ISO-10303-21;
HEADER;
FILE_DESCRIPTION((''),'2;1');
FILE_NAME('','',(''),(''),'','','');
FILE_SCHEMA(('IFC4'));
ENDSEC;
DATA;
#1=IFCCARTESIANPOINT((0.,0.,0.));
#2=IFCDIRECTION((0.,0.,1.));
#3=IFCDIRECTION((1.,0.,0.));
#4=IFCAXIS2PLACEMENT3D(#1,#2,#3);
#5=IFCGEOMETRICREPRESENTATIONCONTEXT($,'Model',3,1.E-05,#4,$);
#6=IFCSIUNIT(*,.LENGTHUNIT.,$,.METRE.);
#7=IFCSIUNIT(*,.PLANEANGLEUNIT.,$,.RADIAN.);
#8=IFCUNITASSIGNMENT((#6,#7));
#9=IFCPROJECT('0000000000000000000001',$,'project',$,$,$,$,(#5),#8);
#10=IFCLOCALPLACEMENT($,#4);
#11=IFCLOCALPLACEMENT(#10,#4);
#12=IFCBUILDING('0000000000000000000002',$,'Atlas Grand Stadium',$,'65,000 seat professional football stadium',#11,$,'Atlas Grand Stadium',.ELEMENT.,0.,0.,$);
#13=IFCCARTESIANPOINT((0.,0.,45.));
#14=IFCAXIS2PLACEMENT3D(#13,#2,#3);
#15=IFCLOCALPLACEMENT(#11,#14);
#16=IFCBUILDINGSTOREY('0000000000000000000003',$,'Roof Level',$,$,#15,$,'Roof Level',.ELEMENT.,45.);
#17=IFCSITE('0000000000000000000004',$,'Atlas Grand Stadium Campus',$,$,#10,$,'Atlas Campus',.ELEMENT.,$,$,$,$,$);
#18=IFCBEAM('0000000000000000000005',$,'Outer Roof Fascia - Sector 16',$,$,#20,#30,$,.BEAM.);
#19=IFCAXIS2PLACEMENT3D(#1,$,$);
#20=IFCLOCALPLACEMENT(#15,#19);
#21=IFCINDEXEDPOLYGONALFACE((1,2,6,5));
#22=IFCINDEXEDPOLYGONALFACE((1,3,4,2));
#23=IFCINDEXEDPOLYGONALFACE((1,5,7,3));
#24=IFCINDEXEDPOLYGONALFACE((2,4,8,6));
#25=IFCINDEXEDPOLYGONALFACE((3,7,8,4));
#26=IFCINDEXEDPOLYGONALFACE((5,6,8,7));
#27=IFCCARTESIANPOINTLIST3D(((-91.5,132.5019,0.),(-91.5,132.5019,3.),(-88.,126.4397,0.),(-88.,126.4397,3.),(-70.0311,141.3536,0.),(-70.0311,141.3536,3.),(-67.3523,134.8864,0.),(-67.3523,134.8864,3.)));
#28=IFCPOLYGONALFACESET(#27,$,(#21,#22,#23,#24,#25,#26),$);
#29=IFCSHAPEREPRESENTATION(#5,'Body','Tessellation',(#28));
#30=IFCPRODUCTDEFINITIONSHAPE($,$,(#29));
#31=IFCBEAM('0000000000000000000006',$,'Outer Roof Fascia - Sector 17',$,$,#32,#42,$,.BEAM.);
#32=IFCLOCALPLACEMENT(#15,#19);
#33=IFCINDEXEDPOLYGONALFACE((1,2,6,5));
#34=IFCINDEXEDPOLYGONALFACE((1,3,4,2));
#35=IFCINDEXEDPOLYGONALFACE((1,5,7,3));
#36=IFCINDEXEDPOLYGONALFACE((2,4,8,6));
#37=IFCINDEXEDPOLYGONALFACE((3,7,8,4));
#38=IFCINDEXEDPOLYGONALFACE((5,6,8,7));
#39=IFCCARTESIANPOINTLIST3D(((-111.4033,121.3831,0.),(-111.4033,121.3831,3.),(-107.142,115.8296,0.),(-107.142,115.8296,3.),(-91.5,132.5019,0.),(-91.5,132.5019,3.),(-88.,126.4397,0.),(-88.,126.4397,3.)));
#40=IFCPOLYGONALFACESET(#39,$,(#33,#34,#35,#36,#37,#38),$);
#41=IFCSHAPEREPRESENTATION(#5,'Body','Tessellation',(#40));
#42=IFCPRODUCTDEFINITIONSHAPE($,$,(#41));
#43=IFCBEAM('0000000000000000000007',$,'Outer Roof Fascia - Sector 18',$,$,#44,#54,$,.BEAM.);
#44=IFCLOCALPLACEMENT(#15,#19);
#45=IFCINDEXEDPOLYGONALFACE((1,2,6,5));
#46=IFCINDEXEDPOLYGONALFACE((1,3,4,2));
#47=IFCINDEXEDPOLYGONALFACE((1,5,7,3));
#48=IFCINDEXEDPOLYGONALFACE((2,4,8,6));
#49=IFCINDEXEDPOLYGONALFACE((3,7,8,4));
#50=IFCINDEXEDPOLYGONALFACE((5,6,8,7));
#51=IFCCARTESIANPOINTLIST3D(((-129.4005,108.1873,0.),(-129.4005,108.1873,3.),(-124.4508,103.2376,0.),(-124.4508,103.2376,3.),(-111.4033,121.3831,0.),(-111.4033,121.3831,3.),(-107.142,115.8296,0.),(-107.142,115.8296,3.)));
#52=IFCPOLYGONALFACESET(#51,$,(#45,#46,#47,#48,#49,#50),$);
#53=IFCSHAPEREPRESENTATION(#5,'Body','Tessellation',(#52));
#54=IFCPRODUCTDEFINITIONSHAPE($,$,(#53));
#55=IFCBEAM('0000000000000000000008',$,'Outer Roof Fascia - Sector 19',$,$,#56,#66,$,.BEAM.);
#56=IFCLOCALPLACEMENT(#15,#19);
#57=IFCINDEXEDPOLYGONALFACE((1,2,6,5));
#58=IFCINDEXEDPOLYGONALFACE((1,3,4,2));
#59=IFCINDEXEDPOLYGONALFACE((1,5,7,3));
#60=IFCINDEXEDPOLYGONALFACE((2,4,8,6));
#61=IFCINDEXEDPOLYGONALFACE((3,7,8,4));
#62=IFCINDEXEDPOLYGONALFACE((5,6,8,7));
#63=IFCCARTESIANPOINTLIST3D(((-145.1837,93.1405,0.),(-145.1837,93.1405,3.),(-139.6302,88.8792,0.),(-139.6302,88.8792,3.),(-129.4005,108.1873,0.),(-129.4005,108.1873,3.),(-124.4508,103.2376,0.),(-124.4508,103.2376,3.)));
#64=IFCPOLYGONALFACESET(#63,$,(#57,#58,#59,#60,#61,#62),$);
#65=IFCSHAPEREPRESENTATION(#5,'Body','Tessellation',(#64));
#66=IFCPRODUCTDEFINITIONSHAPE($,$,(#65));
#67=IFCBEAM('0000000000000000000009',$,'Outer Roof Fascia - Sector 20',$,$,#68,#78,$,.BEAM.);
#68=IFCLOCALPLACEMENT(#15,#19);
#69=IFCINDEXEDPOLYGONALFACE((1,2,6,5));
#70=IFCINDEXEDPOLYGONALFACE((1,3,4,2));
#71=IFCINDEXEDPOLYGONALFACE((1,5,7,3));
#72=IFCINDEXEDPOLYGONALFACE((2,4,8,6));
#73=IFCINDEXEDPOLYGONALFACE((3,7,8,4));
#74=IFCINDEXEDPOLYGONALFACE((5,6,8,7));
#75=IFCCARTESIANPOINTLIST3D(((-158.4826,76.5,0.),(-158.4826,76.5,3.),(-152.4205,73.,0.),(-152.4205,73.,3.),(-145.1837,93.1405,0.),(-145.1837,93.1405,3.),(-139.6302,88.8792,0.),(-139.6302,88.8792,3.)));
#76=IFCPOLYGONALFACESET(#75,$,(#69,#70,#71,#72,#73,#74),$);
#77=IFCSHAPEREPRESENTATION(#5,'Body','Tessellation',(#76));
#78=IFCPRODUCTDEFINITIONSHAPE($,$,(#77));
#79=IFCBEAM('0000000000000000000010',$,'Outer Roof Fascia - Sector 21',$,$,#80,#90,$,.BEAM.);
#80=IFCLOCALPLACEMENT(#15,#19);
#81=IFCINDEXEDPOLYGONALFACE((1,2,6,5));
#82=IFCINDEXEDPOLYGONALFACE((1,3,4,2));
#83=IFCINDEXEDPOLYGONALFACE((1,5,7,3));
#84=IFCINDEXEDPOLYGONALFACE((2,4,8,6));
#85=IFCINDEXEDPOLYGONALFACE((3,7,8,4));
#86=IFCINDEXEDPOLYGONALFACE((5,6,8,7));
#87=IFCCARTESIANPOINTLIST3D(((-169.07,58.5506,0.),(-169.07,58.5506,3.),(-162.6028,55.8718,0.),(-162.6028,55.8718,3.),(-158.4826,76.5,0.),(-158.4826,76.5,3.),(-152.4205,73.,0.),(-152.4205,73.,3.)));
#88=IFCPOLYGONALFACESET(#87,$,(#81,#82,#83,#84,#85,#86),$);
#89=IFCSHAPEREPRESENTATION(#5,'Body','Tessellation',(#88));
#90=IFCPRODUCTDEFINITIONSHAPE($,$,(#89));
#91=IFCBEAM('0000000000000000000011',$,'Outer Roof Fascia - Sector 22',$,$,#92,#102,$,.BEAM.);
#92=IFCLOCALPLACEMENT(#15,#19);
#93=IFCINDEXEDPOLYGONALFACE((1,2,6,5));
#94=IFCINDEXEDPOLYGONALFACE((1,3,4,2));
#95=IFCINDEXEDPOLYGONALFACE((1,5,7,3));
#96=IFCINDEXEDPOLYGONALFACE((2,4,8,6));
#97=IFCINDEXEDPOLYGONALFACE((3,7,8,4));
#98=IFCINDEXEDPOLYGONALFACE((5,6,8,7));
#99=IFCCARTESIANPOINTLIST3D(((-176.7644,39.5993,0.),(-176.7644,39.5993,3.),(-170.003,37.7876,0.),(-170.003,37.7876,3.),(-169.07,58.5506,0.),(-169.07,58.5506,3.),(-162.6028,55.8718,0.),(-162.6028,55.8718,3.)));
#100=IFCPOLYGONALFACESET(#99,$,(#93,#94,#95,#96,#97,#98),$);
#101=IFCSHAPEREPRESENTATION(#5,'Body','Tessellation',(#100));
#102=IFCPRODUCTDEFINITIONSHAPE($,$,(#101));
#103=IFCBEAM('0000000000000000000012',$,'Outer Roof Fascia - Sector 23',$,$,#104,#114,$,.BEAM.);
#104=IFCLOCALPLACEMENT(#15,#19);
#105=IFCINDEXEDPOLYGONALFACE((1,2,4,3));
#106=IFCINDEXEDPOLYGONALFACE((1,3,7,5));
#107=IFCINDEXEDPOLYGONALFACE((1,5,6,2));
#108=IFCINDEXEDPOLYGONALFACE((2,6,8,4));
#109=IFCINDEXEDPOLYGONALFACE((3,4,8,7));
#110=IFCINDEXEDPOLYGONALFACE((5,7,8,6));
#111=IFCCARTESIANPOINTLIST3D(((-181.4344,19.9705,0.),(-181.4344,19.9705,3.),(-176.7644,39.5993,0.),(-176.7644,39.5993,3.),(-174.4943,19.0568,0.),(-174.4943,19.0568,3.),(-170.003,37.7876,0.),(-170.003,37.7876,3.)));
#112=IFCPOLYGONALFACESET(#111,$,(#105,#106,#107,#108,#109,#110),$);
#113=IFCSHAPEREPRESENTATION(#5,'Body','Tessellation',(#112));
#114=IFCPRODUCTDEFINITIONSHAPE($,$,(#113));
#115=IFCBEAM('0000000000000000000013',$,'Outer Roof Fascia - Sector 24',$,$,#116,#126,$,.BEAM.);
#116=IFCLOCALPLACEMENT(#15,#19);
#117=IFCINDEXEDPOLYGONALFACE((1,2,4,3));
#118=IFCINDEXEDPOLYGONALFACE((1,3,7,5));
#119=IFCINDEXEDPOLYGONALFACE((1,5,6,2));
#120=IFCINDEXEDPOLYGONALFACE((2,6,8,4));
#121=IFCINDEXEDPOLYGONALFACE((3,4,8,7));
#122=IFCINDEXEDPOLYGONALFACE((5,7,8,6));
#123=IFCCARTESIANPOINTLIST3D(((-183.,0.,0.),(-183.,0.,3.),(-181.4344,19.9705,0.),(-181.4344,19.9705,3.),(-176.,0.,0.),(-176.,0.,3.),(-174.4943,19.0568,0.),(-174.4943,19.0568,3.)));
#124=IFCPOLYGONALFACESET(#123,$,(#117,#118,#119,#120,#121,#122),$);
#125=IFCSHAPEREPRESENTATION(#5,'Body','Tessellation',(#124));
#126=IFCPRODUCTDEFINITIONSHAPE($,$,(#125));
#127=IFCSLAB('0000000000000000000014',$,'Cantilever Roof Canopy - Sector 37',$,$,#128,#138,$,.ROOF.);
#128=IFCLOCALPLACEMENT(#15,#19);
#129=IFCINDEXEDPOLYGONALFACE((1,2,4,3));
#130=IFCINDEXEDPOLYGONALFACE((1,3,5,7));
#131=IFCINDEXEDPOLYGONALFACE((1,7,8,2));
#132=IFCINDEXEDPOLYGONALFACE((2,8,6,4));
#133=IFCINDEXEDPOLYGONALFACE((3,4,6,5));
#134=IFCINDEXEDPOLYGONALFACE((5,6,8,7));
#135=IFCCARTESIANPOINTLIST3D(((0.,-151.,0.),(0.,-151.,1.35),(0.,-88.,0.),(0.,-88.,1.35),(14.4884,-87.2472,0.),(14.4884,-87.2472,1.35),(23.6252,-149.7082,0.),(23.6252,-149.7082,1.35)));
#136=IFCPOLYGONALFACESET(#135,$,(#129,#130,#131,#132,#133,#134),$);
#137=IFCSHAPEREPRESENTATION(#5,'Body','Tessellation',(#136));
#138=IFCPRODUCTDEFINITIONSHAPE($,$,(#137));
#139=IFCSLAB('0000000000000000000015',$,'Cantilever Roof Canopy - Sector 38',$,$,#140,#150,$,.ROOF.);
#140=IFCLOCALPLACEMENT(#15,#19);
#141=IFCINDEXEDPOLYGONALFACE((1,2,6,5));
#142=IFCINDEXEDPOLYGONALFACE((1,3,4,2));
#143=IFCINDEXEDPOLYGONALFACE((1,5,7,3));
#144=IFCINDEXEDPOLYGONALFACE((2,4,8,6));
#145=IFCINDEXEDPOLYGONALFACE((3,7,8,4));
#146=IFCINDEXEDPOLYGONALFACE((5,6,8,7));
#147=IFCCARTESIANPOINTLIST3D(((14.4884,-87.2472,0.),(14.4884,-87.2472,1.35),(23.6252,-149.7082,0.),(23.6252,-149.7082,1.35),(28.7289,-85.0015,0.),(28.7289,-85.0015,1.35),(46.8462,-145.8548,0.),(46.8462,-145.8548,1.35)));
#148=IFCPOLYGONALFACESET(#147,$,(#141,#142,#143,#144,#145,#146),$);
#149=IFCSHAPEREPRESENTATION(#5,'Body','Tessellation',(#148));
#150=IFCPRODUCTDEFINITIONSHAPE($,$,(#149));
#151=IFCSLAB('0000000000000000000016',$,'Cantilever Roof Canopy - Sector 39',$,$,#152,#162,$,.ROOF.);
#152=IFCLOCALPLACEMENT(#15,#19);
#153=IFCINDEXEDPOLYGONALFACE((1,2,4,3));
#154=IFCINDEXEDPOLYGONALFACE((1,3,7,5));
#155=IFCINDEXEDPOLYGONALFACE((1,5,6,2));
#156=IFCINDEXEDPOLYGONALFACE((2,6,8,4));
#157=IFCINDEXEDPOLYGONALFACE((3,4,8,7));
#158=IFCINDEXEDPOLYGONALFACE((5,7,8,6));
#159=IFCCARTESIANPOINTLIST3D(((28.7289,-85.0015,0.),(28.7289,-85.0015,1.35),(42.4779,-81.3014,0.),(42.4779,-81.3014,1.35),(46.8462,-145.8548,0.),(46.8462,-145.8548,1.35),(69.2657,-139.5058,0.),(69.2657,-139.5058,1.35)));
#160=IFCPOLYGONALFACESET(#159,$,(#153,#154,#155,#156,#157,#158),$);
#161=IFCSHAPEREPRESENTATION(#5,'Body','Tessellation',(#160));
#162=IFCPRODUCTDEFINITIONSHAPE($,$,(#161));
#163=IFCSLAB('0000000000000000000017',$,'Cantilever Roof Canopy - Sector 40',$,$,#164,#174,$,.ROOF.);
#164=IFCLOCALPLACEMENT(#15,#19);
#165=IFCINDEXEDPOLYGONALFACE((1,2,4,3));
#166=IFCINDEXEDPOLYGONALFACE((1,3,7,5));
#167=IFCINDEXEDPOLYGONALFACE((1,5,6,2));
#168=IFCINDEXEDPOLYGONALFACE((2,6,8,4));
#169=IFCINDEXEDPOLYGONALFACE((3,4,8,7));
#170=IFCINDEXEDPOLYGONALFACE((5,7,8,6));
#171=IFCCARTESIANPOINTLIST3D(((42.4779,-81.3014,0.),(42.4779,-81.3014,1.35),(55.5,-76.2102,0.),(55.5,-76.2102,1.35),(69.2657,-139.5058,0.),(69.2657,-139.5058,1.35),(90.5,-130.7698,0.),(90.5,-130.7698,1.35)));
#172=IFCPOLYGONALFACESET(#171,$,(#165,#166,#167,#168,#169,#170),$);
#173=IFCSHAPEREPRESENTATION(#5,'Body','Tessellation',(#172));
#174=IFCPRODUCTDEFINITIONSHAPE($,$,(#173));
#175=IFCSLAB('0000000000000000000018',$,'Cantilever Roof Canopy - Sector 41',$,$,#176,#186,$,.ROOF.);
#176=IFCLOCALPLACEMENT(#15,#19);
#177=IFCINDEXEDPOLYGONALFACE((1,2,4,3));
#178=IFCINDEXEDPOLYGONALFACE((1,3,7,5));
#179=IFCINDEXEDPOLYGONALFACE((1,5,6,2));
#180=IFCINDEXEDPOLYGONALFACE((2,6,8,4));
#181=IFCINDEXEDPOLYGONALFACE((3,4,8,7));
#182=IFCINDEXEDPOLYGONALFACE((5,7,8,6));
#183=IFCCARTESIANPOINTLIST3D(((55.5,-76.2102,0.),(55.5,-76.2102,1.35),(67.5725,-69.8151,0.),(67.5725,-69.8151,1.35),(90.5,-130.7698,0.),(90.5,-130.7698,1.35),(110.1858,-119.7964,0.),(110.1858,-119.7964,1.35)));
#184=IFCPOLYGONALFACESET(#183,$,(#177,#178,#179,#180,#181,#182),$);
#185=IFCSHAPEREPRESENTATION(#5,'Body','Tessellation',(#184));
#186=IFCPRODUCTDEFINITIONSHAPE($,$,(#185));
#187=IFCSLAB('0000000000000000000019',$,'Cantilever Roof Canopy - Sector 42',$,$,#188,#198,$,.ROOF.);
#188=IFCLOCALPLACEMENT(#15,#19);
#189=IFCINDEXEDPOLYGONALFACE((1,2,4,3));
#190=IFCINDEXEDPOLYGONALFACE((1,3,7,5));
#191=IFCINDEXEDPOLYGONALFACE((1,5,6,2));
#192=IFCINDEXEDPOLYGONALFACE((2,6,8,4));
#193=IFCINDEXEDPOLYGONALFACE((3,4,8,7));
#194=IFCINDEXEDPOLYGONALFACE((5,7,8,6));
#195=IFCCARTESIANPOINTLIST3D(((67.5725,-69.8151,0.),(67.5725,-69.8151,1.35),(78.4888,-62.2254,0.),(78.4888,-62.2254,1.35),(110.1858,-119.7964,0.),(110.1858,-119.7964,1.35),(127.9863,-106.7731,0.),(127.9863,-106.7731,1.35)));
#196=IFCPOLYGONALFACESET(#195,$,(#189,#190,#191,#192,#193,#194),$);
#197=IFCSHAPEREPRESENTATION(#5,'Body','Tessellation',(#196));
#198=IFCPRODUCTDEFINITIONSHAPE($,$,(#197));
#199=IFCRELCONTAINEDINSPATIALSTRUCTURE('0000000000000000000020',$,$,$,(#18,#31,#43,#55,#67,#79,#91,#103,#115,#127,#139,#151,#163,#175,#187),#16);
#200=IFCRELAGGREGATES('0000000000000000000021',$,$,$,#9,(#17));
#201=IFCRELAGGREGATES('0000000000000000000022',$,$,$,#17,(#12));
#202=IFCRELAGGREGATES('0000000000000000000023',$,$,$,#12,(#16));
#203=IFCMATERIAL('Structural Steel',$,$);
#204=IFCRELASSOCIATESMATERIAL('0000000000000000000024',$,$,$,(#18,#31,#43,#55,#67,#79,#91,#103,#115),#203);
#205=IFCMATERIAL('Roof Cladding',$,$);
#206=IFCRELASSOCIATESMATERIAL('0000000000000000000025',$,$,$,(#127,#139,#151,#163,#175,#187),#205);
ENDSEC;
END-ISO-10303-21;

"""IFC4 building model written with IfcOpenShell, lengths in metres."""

from ifc_helpers import new_model, si_unit, frame, origin_with_axes, place, context, project, spatial, polyline, outline, extrude, material, element, save


model = new_model("IFC4")

# Units and contexts
model_context = context("Model", 3, precision=1e-05, world=origin_with_axes())
ifc_project = project(units=[si_unit("LENGTHUNIT", "METRE"), si_unit("PLANEANGLEUNIT", "RADIAN")], contexts=[model_context])

# Site, building, storey
site_placement = place(None, origin_with_axes())
site = spatial("IfcSite", under=ifc_project, at=site_placement, Name="Atlas Grand Stadium Campus", LongName="Atlas Campus", CompositionType="ELEMENT")
building_placement = place(site_placement, origin_with_axes())
building = spatial("IfcBuilding", under=site, at=building_placement, Name="Atlas Grand Stadium", ObjectType="65,000 seat professional football stadium", LongName="Atlas Grand Stadium", CompositionType="ELEMENT", ElevationOfRefHeight=0.0, ElevationOfTerrain=0.0)
storey_placement = place(building_placement, frame((0.0, 0.0, 45.0), z_axis=(0.0, 0.0, 1.0), x_axis=(1.0, 0.0, 0.0)))
storey = spatial("IfcBuildingStorey", under=building, at=storey_placement, Name="Roof Level", LongName="Roof Level", CompositionType="ELEMENT", Elevation=45.0)

# Beams
ifc_material_1 = material(Name="Structural Steel")
beam_1_placement = place(storey_placement, origin_with_axes())
element("IfcBeam", 1, at=beam_1_placement, inside=storey, material=ifc_material_1, Name="Outer Roof Fascia - Sector 16", PredefinedType="BEAM", context=model_context, shape_type="SweptSolid", body=[
    extrude(outline(polyline([(-70.0311, 141.3536), (-91.5, 132.5019), (-88.0, 126.4397), (-67.3523, 134.8864), (-70.0311, 141.3536)])), origin_with_axes(), (0.0, 0.0, 1.0), 3.0),
])
beam_2_placement = place(storey_placement, origin_with_axes())
element("IfcBeam", 2, at=beam_2_placement, inside=storey, material=ifc_material_1, Name="Outer Roof Fascia - Sector 17", PredefinedType="BEAM", context=model_context, shape_type="SweptSolid", body=[
    extrude(outline(polyline([(-91.5, 132.5019), (-111.4033, 121.3831), (-107.142, 115.8296), (-88.0, 126.4397), (-91.5, 132.5019)])), origin_with_axes(), (0.0, 0.0, 1.0), 3.0),
])
beam_3_placement = place(storey_placement, origin_with_axes())
element("IfcBeam", 3, at=beam_3_placement, inside=storey, material=ifc_material_1, Name="Outer Roof Fascia - Sector 18", PredefinedType="BEAM", context=model_context, shape_type="SweptSolid", body=[
    extrude(outline(polyline([(-111.4033, 121.3831), (-129.4005, 108.1873), (-124.4508, 103.2376), (-107.142, 115.8296), (-111.4033, 121.3831)])), origin_with_axes(), (0.0, 0.0, 1.0), 3.0),
])
beam_4_placement = place(storey_placement, origin_with_axes())
element("IfcBeam", 4, at=beam_4_placement, inside=storey, material=ifc_material_1, Name="Outer Roof Fascia - Sector 19", PredefinedType="BEAM", context=model_context, shape_type="SweptSolid", body=[
    extrude(outline(polyline([(-129.4005, 108.1873), (-145.1837, 93.1405), (-139.6302, 88.8792), (-124.4508, 103.2376), (-129.4005, 108.1873)])), origin_with_axes(), (0.0, 0.0, 1.0), 3.0),
])
beam_5_placement = place(storey_placement, origin_with_axes())
element("IfcBeam", 5, at=beam_5_placement, inside=storey, material=ifc_material_1, Name="Outer Roof Fascia - Sector 20", PredefinedType="BEAM", context=model_context, shape_type="SweptSolid", body=[
    extrude(outline(polyline([(-145.1837, 93.1405), (-158.4827, 76.5), (-152.4205, 73.0), (-139.6302, 88.8792), (-145.1837, 93.1405)])), origin_with_axes(), (0.0, 0.0, 1.0), 3.0),
])
beam_6_placement = place(storey_placement, origin_with_axes())
element("IfcBeam", 6, at=beam_6_placement, inside=storey, material=ifc_material_1, Name="Outer Roof Fascia - Sector 21", PredefinedType="BEAM", context=model_context, shape_type="SweptSolid", body=[
    extrude(outline(polyline([(-158.4827, 76.5), (-169.07, 58.5506), (-162.6028, 55.8718), (-152.4205, 73.0), (-158.4827, 76.5)])), origin_with_axes(), (0.0, 0.0, 1.0), 3.0),
])
beam_7_placement = place(storey_placement, origin_with_axes())
element("IfcBeam", 7, at=beam_7_placement, inside=storey, material=ifc_material_1, Name="Outer Roof Fascia - Sector 22", PredefinedType="BEAM", context=model_context, shape_type="SweptSolid", body=[
    extrude(outline(polyline([(-169.07, 58.5506), (-176.7644, 39.5993), (-170.0029, 37.7876), (-162.6028, 55.8718), (-169.07, 58.5506)])), origin_with_axes(), (0.0, 0.0, 1.0), 3.0),
])
beam_8_placement = place(storey_placement, origin_with_axes())
element("IfcBeam", 8, at=beam_8_placement, inside=storey, material=ifc_material_1, Name="Outer Roof Fascia - Sector 23", PredefinedType="BEAM", context=model_context, shape_type="SweptSolid", body=[
    extrude(outline(polyline([(-176.7644, 39.5993), (-181.4344, 19.9705), (-174.4943, 19.0568), (-170.0029, 37.7876), (-176.7644, 39.5993)])), origin_with_axes(), (0.0, 0.0, 1.0), 3.0),
])
beam_9_placement = place(storey_placement, origin_with_axes())
element("IfcBeam", 9, at=beam_9_placement, inside=storey, material=ifc_material_1, Name="Outer Roof Fascia - Sector 24", PredefinedType="BEAM", context=model_context, shape_type="SweptSolid", body=[
    extrude(outline(polyline([(-181.4344, 19.9705), (-183.0, 0.0), (-176.0, 0.0), (-174.4943, 19.0568), (-181.4344, 19.9705)])), origin_with_axes(), (0.0, 0.0, 1.0), 3.0),
])

# Slabs
ifc_material_2 = material(Name="Roof Cladding")
slab_1_placement = place(storey_placement, origin_with_axes())
element("IfcSlab", 10, at=slab_1_placement, inside=storey, material=ifc_material_2, Name="Cantilever Roof Canopy - Sector 37", PredefinedType="ROOF", context=model_context, shape_type="SweptSolid", body=[
    extrude(outline(polyline([(0.0, -151.0), (23.6252, -149.7082), (14.4884, -87.2472), (0.0, -88.0), (0.0, -151.0)])), origin_with_axes(), (0.0, 0.0, 1.0), 1.35),
])
slab_2_placement = place(storey_placement, origin_with_axes())
element("IfcSlab", 11, at=slab_2_placement, inside=storey, material=ifc_material_2, Name="Cantilever Roof Canopy - Sector 38", PredefinedType="ROOF", context=model_context, shape_type="SweptSolid", body=[
    extrude(outline(polyline([(23.6252, -149.7082), (46.8462, -145.8548), (28.7289, -85.0015), (14.4884, -87.2472), (23.6252, -149.7082)])), origin_with_axes(), (0.0, 0.0, 1.0), 1.35),
])
slab_3_placement = place(storey_placement, origin_with_axes())
element("IfcSlab", 12, at=slab_3_placement, inside=storey, material=ifc_material_2, Name="Cantilever Roof Canopy - Sector 39", PredefinedType="ROOF", context=model_context, shape_type="SweptSolid", body=[
    extrude(outline(polyline([(46.8462, -145.8548), (69.2657, -139.5058), (42.4779, -81.3014), (28.7289, -85.0015), (46.8462, -145.8548)])), origin_with_axes(), (0.0, 0.0, 1.0), 1.35),
])
slab_4_placement = place(storey_placement, origin_with_axes())
element("IfcSlab", 13, at=slab_4_placement, inside=storey, material=ifc_material_2, Name="Cantilever Roof Canopy - Sector 40", PredefinedType="ROOF", context=model_context, shape_type="SweptSolid", body=[
    extrude(outline(polyline([(69.2657, -139.5058), (90.5, -130.7698), (55.5, -76.2102), (42.4779, -81.3014), (69.2657, -139.5058)])), origin_with_axes(), (0.0, 0.0, 1.0), 1.35),
])
slab_5_placement = place(storey_placement, origin_with_axes())
element("IfcSlab", 14, at=slab_5_placement, inside=storey, material=ifc_material_2, Name="Cantilever Roof Canopy - Sector 41", PredefinedType="ROOF", context=model_context, shape_type="SweptSolid", body=[
    extrude(outline(polyline([(90.5, -130.7698), (110.1858, -119.7964), (67.5725, -69.8151), (55.5, -76.2102), (90.5, -130.7698)])), origin_with_axes(), (0.0, 0.0, 1.0), 1.35),
])
slab_6_placement = place(storey_placement, origin_with_axes())
element("IfcSlab", 15, at=slab_6_placement, inside=storey, material=ifc_material_2, Name="Cantilever Roof Canopy - Sector 42", PredefinedType="ROOF", context=model_context, shape_type="SweptSolid", body=[
    extrude(outline(polyline([(110.1858, -119.7964), (127.9863, -106.7731), (78.4888, -62.2254), (67.5725, -69.8151), (110.1858, -119.7964)])), origin_with_axes(), (0.0, 0.0, 1.0), 1.35),
])

save(model, "model.ifc")
